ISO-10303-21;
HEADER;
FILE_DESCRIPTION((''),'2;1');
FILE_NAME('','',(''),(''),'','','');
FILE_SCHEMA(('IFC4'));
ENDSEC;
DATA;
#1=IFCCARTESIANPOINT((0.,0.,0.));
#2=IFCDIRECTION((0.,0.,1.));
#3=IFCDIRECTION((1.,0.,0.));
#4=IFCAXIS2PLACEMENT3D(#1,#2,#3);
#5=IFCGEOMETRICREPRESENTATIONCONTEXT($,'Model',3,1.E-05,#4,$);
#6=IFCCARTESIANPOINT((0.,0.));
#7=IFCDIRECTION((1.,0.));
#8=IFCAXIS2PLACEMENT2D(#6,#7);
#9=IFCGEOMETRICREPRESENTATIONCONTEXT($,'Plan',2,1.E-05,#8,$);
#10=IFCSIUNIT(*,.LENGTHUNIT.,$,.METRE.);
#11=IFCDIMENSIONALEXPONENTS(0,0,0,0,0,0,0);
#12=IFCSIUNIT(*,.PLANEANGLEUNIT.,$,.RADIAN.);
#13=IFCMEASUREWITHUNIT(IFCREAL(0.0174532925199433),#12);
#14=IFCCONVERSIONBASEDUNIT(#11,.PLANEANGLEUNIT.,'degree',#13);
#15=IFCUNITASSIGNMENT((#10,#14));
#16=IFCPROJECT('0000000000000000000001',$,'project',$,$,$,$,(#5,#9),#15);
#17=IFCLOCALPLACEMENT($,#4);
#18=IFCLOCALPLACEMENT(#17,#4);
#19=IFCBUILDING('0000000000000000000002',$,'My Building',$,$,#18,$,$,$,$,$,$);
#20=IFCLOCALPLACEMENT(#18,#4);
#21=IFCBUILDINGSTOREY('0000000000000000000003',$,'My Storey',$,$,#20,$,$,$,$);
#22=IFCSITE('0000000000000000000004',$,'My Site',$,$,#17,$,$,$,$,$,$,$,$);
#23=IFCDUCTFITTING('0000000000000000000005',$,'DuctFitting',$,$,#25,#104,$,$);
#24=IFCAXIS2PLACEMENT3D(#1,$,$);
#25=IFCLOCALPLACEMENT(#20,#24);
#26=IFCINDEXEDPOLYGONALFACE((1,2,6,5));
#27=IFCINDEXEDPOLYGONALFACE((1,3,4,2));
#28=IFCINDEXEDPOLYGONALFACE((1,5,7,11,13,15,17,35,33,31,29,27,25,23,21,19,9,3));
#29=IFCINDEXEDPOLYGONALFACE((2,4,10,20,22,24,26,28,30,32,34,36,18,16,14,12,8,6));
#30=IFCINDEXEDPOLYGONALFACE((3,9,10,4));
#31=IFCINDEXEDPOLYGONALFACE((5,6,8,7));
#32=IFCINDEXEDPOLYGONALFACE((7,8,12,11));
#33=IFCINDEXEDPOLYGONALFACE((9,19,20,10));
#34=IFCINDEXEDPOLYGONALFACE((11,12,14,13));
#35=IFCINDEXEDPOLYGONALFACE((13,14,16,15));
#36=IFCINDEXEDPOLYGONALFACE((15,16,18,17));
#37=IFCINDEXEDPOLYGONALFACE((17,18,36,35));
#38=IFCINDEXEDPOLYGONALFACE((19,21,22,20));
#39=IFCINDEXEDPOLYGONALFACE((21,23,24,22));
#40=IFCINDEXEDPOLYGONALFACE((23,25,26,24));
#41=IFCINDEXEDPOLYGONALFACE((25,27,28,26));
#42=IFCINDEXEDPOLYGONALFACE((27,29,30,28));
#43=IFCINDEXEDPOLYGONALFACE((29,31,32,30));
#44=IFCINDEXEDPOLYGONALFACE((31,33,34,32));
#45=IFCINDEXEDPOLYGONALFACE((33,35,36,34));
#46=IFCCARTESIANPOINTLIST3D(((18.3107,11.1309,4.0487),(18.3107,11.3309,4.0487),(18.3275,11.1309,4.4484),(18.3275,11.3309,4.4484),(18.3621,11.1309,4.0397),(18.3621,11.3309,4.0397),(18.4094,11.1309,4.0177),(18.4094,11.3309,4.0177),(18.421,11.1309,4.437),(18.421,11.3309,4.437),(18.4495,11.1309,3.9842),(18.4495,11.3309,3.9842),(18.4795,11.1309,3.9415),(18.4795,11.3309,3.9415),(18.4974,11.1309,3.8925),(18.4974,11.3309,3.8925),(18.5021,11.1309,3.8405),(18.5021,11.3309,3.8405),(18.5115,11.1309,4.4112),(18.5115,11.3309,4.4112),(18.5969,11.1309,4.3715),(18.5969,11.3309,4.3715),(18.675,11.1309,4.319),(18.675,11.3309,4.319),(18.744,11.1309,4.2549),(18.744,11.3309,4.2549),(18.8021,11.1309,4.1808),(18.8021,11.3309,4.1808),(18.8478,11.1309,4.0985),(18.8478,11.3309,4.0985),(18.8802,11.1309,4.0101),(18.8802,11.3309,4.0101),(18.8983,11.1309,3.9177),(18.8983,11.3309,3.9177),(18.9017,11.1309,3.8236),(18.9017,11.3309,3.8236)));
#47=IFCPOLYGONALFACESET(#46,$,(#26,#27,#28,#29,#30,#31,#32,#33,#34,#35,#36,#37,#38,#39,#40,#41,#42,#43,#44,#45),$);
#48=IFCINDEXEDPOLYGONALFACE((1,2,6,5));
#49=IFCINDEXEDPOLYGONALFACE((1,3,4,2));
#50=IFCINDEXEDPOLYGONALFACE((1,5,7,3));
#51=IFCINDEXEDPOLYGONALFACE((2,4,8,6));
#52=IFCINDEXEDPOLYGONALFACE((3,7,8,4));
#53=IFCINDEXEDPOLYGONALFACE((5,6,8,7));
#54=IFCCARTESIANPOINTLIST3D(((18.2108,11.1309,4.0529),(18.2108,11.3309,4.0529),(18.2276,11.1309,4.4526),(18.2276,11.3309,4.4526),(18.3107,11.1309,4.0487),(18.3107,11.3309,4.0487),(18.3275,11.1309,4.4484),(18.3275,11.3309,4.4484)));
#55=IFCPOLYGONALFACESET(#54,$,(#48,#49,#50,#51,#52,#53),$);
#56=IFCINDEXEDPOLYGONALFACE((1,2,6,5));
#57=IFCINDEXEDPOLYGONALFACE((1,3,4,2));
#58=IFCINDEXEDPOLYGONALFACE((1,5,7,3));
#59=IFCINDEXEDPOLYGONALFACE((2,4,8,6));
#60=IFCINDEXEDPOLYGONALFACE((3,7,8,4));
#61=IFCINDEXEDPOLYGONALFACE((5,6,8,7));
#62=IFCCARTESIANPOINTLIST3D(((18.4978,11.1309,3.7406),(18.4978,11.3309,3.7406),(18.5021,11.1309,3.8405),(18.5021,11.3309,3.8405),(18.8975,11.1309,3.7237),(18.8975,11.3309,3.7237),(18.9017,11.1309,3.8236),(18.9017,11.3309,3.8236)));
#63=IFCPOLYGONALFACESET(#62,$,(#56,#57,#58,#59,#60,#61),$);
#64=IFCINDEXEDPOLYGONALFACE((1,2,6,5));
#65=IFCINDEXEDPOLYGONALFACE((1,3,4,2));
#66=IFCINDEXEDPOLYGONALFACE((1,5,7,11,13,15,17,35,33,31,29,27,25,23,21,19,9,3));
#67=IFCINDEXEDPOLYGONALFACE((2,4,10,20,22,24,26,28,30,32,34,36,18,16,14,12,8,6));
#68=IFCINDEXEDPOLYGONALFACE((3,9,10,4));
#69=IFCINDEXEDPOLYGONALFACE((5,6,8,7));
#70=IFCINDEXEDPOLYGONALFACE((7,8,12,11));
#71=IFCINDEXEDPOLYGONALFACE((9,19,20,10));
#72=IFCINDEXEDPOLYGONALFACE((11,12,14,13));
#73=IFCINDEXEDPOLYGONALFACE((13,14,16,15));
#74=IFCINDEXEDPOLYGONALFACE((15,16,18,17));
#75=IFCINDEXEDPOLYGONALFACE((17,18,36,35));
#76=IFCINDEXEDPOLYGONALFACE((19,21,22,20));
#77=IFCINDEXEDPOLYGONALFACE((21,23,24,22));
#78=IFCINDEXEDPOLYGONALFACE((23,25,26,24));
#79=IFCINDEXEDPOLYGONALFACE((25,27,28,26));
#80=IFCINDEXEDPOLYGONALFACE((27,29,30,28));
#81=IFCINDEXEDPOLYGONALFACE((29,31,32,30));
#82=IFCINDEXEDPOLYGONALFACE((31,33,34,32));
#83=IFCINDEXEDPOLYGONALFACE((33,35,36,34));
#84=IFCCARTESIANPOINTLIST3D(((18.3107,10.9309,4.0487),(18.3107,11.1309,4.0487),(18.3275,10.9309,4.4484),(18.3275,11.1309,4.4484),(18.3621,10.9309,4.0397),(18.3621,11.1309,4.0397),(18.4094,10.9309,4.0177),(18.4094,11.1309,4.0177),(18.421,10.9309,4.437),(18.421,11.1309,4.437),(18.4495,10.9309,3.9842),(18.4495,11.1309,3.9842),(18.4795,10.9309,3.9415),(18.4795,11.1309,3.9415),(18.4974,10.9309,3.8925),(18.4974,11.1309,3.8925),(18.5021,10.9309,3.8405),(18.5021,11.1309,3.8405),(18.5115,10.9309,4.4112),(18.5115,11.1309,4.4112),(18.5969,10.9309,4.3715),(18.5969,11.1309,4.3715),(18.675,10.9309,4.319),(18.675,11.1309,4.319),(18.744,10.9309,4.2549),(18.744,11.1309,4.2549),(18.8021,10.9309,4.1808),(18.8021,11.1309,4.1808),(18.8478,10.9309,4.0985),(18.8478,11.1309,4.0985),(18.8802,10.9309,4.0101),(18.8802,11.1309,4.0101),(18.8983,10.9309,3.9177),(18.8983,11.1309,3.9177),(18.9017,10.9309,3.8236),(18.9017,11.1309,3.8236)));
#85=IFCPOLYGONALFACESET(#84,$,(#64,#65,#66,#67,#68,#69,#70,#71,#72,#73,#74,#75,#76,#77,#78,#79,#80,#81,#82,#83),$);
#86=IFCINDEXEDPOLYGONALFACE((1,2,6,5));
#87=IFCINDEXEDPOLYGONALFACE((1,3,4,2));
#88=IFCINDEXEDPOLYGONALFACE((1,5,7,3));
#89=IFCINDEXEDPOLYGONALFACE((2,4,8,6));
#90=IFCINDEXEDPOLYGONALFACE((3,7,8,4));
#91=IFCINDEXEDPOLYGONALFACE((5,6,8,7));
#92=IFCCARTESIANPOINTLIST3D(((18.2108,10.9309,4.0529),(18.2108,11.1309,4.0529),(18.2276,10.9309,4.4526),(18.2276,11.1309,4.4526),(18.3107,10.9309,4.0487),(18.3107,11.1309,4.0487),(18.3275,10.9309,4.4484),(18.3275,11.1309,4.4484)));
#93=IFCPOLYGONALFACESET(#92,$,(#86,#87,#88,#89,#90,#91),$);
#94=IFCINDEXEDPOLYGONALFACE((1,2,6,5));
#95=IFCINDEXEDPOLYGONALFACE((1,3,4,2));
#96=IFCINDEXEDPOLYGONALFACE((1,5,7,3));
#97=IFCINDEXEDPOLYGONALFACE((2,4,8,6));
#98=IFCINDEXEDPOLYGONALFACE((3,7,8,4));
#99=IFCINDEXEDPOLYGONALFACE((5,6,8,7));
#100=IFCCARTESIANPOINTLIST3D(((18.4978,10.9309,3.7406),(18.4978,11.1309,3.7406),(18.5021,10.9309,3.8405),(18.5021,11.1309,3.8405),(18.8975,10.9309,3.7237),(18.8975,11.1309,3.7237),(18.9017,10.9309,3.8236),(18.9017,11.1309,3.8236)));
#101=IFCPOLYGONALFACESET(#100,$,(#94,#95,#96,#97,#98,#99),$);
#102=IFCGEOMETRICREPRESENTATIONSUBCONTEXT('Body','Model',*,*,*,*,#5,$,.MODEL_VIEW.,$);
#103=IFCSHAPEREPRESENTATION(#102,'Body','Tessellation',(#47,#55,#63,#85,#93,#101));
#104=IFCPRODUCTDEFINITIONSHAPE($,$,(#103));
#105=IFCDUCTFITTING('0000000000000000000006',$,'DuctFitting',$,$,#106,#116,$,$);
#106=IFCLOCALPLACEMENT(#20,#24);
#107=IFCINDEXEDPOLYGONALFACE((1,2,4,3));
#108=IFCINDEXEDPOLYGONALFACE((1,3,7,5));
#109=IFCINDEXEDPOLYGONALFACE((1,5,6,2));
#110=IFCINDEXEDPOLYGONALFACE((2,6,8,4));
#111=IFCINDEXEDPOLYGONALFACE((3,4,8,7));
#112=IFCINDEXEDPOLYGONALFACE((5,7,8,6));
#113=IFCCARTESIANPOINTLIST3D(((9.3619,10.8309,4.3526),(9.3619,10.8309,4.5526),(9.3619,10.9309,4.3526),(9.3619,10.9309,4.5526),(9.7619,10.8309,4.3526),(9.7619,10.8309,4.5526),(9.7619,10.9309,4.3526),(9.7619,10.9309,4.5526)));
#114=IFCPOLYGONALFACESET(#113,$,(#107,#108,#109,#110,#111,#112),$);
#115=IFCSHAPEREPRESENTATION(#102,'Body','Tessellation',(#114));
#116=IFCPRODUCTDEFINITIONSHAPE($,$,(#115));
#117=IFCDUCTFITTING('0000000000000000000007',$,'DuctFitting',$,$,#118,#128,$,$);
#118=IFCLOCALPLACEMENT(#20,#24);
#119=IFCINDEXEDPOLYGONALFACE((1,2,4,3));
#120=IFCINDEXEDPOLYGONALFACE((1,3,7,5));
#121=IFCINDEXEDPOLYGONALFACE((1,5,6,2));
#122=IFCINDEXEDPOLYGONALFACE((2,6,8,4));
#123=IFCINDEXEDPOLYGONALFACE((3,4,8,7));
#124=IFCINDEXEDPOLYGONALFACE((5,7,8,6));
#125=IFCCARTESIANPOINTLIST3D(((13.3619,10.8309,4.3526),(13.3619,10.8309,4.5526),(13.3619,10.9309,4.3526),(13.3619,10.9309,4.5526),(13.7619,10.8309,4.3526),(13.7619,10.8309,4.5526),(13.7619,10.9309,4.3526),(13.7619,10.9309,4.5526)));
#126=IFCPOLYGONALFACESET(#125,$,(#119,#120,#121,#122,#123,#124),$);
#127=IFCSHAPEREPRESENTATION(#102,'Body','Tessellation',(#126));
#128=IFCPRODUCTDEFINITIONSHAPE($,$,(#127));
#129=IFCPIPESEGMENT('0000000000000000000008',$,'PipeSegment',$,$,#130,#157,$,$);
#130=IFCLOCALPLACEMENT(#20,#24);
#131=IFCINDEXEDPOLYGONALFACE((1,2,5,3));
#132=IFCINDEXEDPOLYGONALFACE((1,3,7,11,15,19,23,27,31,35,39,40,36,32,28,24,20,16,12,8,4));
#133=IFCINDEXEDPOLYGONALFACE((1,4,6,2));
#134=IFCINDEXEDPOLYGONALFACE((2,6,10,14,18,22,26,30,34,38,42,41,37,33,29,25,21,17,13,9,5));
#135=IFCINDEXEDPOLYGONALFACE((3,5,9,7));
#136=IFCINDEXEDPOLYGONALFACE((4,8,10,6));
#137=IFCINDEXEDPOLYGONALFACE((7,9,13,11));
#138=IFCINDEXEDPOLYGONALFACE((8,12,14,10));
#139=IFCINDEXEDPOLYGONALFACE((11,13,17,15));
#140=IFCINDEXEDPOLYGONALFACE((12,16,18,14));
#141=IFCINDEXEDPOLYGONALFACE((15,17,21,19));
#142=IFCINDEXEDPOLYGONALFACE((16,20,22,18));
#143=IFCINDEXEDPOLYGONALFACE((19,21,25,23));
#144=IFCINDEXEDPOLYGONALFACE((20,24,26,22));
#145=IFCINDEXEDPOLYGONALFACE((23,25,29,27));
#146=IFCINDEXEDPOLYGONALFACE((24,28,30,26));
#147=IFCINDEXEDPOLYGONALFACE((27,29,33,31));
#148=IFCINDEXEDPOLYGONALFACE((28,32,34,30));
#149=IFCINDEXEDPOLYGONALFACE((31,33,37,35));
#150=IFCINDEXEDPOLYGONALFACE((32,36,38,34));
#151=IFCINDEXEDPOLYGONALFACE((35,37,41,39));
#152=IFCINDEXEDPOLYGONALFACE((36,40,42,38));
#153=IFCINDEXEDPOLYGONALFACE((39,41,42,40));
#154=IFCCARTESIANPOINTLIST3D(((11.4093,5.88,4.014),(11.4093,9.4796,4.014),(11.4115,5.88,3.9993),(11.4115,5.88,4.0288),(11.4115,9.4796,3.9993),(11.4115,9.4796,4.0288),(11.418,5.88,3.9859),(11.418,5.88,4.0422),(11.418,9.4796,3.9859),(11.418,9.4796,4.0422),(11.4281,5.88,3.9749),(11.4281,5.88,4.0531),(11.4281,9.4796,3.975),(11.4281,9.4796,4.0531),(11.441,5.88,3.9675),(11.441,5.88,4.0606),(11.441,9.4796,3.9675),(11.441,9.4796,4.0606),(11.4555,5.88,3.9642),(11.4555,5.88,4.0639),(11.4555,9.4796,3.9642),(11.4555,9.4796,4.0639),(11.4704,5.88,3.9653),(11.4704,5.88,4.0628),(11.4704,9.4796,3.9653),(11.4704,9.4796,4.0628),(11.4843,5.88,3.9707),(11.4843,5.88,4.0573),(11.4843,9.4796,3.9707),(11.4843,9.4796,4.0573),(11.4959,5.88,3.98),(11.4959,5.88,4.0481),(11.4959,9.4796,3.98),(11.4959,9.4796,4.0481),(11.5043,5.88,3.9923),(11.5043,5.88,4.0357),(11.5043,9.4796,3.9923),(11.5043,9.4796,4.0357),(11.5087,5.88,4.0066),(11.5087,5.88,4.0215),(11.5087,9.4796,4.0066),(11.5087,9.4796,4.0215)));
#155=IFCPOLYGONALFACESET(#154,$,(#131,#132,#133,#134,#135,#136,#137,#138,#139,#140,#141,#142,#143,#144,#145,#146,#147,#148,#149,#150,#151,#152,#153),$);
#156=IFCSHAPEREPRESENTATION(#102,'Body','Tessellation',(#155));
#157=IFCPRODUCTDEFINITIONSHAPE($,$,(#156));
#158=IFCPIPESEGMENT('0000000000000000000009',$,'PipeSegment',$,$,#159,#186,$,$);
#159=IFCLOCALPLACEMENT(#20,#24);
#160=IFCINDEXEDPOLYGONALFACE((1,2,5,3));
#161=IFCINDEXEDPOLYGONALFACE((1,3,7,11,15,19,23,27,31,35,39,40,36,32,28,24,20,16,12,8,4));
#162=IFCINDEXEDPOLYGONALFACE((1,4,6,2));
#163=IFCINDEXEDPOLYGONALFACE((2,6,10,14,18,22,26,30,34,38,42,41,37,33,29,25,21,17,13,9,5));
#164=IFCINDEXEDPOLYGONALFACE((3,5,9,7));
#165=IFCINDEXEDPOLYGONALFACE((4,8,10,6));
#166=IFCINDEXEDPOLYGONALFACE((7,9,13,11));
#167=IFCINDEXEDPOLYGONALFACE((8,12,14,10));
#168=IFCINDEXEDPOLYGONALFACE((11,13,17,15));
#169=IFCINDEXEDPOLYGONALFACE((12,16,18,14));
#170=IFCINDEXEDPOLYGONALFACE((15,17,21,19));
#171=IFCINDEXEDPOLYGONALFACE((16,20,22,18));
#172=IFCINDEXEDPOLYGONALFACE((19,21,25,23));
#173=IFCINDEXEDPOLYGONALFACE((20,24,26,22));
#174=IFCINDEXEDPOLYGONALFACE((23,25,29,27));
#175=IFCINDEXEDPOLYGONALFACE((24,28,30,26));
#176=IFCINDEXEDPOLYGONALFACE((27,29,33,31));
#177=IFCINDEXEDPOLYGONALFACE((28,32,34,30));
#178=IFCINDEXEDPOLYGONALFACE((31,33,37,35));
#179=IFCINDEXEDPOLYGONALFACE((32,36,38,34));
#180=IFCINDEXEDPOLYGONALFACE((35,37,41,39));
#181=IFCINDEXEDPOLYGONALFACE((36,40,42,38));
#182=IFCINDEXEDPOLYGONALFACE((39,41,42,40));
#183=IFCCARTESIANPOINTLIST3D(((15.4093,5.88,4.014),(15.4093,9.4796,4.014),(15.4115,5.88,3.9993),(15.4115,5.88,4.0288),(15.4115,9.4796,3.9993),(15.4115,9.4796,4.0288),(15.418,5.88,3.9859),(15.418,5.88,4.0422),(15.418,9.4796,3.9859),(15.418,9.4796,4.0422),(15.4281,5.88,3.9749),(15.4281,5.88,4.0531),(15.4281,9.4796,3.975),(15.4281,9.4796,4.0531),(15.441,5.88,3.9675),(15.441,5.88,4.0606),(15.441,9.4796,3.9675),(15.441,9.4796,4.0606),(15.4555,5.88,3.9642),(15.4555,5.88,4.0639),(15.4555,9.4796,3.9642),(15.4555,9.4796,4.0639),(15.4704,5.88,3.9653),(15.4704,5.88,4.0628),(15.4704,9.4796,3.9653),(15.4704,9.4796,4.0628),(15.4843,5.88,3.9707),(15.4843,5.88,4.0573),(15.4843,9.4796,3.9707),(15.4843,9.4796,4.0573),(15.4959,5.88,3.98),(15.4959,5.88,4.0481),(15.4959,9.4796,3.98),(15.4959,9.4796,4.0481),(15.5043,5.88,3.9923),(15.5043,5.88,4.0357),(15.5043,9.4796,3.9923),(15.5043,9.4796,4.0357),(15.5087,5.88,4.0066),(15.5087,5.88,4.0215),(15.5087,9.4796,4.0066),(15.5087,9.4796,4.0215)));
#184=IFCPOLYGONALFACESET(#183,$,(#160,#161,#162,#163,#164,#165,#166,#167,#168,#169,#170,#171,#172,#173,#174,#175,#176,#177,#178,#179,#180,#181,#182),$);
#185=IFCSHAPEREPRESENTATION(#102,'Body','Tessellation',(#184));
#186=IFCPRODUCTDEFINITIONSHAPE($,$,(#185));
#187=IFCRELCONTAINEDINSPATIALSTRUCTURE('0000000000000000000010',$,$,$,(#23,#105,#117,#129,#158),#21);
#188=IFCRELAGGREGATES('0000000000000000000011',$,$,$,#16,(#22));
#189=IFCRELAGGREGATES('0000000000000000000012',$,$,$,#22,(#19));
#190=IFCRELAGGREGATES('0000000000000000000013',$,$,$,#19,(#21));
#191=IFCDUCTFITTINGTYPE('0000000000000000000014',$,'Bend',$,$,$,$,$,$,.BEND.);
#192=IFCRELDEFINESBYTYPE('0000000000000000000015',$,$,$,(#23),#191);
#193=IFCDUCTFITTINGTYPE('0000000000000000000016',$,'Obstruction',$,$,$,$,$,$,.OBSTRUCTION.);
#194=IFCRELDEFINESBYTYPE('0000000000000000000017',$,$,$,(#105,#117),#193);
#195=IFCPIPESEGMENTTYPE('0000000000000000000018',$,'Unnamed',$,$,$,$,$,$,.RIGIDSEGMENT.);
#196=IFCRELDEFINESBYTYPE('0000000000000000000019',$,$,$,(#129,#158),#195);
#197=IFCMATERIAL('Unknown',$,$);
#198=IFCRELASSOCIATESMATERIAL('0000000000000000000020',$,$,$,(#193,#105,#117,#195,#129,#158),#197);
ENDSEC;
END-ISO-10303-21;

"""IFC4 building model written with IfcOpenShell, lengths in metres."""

from ifc_helpers import new_model, entity, si_unit, converted_unit, frame, origin_with_axes, origin_2d_with_axis, place, context, subcontext, project, spatial, line, arc, indexed_curve, rectangle, circle, outline, extrude, source, transform, mapped, material, material_profile, profile_set, profile_usage, type_object, type_shapes, element, save


model = new_model("IFC4")

# Units and contexts
model_context = context("Model", 3, precision=1e-05, world=origin_with_axes())
plan_context = context("Plan", 2, precision=1e-05, world=origin_2d_with_axis())
body_context_1 = subcontext(model_context, "Body", "Model", "MODEL_VIEW")
ifc_project = project(units=[si_unit("LENGTHUNIT", "METRE"), converted_unit("PLANEANGLEUNIT", "degree", entity("IfcReal", 0.0174532925199433), si_unit("PLANEANGLEUNIT", "RADIAN"), dimensions=[0, 0, 0, 0, 0, 0, 0])], contexts=[model_context, plan_context])

# Site, building, storey
site_placement = place(None, origin_with_axes())
site = spatial("IfcSite", under=ifc_project, at=site_placement, Name="My Site")
building_placement = place(site_placement, origin_with_axes())
building = spatial("IfcBuilding", under=site, at=building_placement, Name="My Building")
storey_placement = place(building_placement, origin_with_axes())
storey = spatial("IfcBuildingStorey", under=building, at=storey_placement, Name="My Storey")

# Shared definitions
ifc_material = material(Name="Unknown")

# Duct fittings
duct_fitting_type_1 = type_object("IfcDuctFittingType", Name="Bend", PredefinedType="BEND")
shared_shape_1 = source(origin_with_axes(), body_context_1, "Body", "SweptSolid", [
    extrude(outline(indexed_curve([(0.2, 0.0), (0.2586, 0.1414), (0.4, 0.2), (0.4, 0.6), (-0.0243, 0.4243), (-0.2, 0.0)], segments=[arc(1, 2, 3), line(3, 4), arc(4, 5, 6), line(6, 1)])), frame((0.0, -0.1, 0.1), z_axis=(0.0, -1.0, 0.0), x_axis=(1.0, 0.0, 0.0)), (0.0, 0.0, -1.0), 0.2),
    extrude(rectangle(XDim=0.4, YDim=0.2), origin_with_axes(), (0.0, 0.0, 1.0), 0.1),
    extrude(rectangle(XDim=0.4, YDim=0.2), frame((0.4, 0.0, 0.5), z_axis=(1.0, 0.0, 0.0), x_axis=(0.0, 0.0, 1.0)), (0.0, 0.0, 1.0), 0.1),
    extrude(outline(indexed_curve([(0.2, 0.0), (0.2586, 0.1414), (0.4, 0.2), (0.4, 0.6), (-0.0243, 0.4243), (-0.2, 0.0)], segments=[arc(1, 2, 3), line(3, 4), arc(4, 5, 6), line(6, 1)])), frame((0.0, -0.3, 0.1), z_axis=(0.0, -1.0, 0.0), x_axis=(1.0, 0.0, 0.0)), (0.0, 0.0, -1.0), 0.2),
    extrude(rectangle(XDim=0.4, YDim=0.2), frame((0.0, -0.2, 0.0), z_axis=(0.0, 0.0, 1.0), x_axis=(1.0, 0.0, 0.0)), (0.0, 0.0, 1.0), 0.1),
    extrude(rectangle(XDim=0.4, YDim=0.2), frame((0.4, -0.2, 0.5), z_axis=(1.0, 0.0, 0.0), x_axis=(0.0, 0.0, 1.0)), (0.0, 0.0, 1.0), 0.1),
])
type_shapes(duct_fitting_type_1, [shared_shape_1])
duct_fitting_1_placement = place(storey_placement, frame((18.2192, 11.2309, 4.2527), z_axis=(0.999112, 0.0, -0.042141), x_axis=(-0.042141, 0.0, -0.999112)))
element("IfcDuctFitting", 1, at=duct_fitting_1_placement, inside=storey, type_object=duct_fitting_type_1, Name="DuctFitting", context=body_context_1, shape_type="MappedRepresentation", body=[
    mapped(shared_shape_1, transform((0.0, 0.0, 0.0), x_axis=(1.0, 0.0, 0.0), y_axis=(0.0, 1.0, 0.0), z_axis=(0.0, 0.0, 1.0), scale=1.0)),
])
ifc_material_profile_1 = material_profile(ifc_material, rectangle(XDim=0.4, YDim=0.2))
ifc_profile_set_1 = profile_set([ifc_material_profile_1])
ifc_profile_usage_1 = profile_usage(ifc_profile_set_1, cardinal=5)
duct_fitting_type_2 = type_object("IfcDuctFittingType", Name="Obstruction", PredefinedType="OBSTRUCTION", material=ifc_profile_set_1)
duct_fitting_2_placement = place(storey_placement, frame((9.5619, 10.9309, 4.4526), z_axis=(0.0, -1.0, 0.0), x_axis=(1.0, 0.0, 0.0)))
element("IfcDuctFitting", 2, at=duct_fitting_2_placement, inside=storey, type_object=duct_fitting_type_2, material=ifc_profile_usage_1, Name="DuctFitting", context=body_context_1, shape_type="SweptSolid", body=[
    extrude(rectangle(XDim=0.4, YDim=0.2), origin_with_axes(), (0.0, 0.0, 1.0), 0.1),
])
ifc_profile_usage_2 = profile_usage(ifc_profile_set_1, cardinal=5)
duct_fitting_3_placement = place(storey_placement, frame((13.5619, 10.9309, 4.4526), z_axis=(0.0, -1.0, 0.0), x_axis=(1.0, 0.0, 0.0)))
element("IfcDuctFitting", 3, at=duct_fitting_3_placement, inside=storey, type_object=duct_fitting_type_2, material=ifc_profile_usage_2, Name="DuctFitting", context=body_context_1, shape_type="SweptSolid", body=[
    extrude(rectangle(XDim=0.4, YDim=0.2), origin_with_axes(), (0.0, 0.0, 1.0), 0.1),
])

# Pipe segments
ifc_material_profile_2 = material_profile(ifc_material, circle(Radius=0.05))
ifc_profile_set_2 = profile_set([ifc_material_profile_2])
ifc_profile_usage_3 = profile_usage(ifc_profile_set_2, cardinal=5)
pipe_segment_type = type_object("IfcPipeSegmentType", Name="Unnamed", PredefinedType="RIGIDSEGMENT", material=ifc_profile_set_2)
pipe_segment_1_placement = place(storey_placement, frame((11.4593, 5.88, 4.014), z_axis=(0.0, 1.0, 0.0), x_axis=(-1.0, 0.0, 0.0)))
element("IfcPipeSegment", 4, at=pipe_segment_1_placement, inside=storey, type_object=pipe_segment_type, material=ifc_profile_usage_3, Name="PipeSegment", context=body_context_1, shape_type="SweptSolid", body=[
    extrude(circle(Radius=0.05), origin_with_axes(), (0.0, 0.0, 1.0), 3.5996),
])
ifc_profile_usage_4 = profile_usage(ifc_profile_set_2, cardinal=5)
pipe_segment_2_placement = place(storey_placement, frame((15.4593, 5.88, 4.014), z_axis=(0.0, 1.0, 0.0), x_axis=(-1.0, 0.0, 0.0)))
element("IfcPipeSegment", 5, at=pipe_segment_2_placement, inside=storey, type_object=pipe_segment_type, material=ifc_profile_usage_4, Name="PipeSegment", context=body_context_1, shape_type="SweptSolid", body=[
    extrude(circle(Radius=0.05), origin_with_axes(), (0.0, 0.0, 1.0), 3.5996),
])

save(model, "model.ifc")
